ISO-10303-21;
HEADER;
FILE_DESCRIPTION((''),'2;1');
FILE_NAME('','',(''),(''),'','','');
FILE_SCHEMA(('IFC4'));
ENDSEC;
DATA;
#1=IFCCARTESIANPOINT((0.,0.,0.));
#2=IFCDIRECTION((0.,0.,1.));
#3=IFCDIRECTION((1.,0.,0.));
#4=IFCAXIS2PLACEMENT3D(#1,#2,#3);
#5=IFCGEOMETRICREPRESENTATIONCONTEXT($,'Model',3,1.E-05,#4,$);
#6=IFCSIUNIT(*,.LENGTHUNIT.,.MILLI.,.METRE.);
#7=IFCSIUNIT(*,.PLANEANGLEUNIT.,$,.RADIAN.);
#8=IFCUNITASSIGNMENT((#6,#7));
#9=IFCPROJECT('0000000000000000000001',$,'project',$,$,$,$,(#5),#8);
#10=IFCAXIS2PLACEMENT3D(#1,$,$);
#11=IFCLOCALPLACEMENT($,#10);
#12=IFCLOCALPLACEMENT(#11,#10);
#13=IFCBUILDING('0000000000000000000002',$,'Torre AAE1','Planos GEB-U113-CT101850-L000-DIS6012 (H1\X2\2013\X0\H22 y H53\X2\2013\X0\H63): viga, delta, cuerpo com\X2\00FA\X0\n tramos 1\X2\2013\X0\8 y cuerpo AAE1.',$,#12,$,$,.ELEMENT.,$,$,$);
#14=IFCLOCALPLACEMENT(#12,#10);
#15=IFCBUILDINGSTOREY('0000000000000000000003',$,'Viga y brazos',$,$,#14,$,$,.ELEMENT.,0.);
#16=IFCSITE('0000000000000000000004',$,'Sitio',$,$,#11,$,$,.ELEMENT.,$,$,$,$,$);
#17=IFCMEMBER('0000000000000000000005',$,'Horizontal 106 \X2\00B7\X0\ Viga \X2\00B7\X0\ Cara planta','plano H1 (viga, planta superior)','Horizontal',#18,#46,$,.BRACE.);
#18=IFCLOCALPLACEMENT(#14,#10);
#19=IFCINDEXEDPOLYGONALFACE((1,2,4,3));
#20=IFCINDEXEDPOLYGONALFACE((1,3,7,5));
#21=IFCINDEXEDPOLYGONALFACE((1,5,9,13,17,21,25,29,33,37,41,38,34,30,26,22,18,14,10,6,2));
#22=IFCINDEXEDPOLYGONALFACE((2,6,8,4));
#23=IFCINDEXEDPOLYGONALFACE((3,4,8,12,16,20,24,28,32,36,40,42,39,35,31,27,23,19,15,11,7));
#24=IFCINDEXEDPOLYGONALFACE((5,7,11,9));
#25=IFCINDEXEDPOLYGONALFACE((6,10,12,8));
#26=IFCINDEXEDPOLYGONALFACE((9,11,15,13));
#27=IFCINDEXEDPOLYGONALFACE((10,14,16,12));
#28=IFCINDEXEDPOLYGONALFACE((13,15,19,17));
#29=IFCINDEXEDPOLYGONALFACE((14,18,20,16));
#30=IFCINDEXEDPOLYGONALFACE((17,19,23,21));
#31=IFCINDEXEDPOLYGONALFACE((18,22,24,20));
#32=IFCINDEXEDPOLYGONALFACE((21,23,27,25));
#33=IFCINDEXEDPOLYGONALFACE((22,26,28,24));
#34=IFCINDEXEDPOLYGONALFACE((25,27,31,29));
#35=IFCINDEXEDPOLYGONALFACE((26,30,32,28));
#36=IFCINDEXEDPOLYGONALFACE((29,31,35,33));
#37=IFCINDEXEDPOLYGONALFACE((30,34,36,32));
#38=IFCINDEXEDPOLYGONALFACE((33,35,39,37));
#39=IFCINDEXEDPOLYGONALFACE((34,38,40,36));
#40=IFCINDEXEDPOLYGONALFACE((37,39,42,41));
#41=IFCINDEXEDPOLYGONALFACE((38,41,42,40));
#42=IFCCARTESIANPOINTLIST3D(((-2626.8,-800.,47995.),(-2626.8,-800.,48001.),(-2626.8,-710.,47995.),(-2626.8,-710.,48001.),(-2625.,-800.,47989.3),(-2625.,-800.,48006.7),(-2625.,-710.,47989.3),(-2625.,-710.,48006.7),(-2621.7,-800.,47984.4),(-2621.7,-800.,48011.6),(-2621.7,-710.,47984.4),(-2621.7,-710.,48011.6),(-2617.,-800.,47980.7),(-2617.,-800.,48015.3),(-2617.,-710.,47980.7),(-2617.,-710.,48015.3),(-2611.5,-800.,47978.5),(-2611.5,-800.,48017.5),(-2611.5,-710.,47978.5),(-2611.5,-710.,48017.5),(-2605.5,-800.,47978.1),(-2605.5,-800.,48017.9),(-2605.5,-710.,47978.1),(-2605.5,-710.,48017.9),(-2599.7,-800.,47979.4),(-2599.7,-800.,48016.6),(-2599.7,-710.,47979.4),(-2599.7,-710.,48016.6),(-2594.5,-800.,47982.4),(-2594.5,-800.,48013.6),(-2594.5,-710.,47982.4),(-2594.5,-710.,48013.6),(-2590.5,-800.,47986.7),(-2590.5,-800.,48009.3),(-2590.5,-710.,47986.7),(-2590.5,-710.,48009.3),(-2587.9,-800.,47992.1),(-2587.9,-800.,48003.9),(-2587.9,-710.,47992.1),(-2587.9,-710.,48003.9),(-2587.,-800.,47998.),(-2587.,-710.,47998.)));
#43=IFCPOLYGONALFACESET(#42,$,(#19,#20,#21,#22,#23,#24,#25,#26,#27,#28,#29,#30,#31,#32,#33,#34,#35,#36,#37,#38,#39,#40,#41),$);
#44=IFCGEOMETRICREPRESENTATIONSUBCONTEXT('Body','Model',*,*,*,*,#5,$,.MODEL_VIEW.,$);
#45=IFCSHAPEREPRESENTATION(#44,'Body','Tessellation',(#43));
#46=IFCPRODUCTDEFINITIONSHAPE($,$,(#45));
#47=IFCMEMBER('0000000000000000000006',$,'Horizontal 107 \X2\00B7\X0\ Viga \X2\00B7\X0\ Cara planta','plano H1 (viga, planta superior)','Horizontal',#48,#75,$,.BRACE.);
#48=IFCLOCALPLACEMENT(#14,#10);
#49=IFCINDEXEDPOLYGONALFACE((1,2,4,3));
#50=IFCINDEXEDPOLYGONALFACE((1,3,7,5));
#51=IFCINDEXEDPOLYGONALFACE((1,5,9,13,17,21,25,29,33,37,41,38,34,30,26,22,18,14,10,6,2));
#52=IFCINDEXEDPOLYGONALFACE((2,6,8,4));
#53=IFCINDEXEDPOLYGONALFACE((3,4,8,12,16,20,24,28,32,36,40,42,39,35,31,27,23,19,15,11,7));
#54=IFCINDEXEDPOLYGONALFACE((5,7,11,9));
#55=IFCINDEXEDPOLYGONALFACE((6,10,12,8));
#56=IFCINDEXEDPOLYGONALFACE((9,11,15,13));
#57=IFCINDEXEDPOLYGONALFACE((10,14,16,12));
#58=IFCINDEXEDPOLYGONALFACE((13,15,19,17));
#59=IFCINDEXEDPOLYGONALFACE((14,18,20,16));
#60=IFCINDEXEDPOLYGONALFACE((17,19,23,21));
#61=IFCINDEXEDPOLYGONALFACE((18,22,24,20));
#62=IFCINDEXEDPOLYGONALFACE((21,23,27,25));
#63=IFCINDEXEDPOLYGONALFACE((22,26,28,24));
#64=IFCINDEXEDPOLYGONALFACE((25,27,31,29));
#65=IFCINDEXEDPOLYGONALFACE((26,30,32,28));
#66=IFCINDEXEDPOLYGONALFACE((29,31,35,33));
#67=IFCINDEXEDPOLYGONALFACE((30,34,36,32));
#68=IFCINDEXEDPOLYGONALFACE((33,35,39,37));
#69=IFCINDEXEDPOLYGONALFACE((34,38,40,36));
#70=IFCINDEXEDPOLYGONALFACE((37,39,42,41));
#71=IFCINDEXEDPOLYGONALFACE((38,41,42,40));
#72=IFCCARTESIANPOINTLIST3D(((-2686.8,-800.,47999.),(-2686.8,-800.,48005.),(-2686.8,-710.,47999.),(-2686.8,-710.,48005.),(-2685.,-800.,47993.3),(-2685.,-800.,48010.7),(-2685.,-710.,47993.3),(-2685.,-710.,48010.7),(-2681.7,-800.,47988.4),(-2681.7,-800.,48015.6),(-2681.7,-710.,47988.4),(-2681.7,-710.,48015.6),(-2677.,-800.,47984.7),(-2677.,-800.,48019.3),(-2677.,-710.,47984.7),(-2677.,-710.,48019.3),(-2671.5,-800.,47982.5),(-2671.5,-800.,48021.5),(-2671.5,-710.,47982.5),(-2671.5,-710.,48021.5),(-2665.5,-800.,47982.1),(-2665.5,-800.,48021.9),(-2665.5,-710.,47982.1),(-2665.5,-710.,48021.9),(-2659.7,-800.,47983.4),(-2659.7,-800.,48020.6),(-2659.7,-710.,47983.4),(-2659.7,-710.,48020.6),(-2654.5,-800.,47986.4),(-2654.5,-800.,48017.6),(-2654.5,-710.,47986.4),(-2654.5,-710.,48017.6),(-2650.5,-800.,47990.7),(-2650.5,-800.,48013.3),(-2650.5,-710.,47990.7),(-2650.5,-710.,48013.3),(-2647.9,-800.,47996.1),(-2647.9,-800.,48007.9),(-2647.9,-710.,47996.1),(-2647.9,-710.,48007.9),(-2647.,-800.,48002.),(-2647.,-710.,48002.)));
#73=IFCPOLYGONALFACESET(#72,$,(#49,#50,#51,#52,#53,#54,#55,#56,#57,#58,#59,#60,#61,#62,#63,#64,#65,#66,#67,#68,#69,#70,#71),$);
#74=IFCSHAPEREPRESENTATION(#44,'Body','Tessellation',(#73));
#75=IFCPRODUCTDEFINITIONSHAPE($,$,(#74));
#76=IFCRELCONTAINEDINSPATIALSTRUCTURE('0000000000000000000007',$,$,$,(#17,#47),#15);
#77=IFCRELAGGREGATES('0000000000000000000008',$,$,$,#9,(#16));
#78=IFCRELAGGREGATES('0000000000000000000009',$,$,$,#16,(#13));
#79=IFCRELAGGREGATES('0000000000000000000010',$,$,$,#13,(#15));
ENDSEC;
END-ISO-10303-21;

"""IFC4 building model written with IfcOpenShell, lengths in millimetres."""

from ifc_helpers import new_model, si_unit, frame, origin, origin_with_axes, place, context, subcontext, project, spatial, circle, extrude, element, save


model = new_model("IFC4")

# Units and contexts
model_context = context("Model", 3, precision=1e-05, world=origin_with_axes())
body_context = subcontext(model_context, "Body", "Model", "MODEL_VIEW")
ifc_project = project(units=[si_unit("LENGTHUNIT", "METRE", prefix="MILLI"), si_unit("PLANEANGLEUNIT", "RADIAN")], contexts=[model_context])

# Site, building, storey
site_placement = place(None, origin())
site = spatial("IfcSite", under=ifc_project, at=site_placement, Name="Sitio", CompositionType="ELEMENT")
building_placement = place(site_placement, origin())
building = spatial("IfcBuilding", under=site, at=building_placement, Name="Torre AAE1", Description="Planos GEB-U113-CT101850-L000-DIS6012 (H1–H22 y H53–H63): viga, delta, cuerpo común tramos 1–8 y cuerpo AAE1.", CompositionType="ELEMENT")
storey_placement = place(building_placement, origin())
storey = spatial("IfcBuildingStorey", under=building, at=storey_placement, Name="Viga y brazos", CompositionType="ELEMENT", Elevation=0.0)

# Members
for number, where, z_axis, x_axis, name in (
    (1, (-2607.0, -710.0, 47998.0), (0.0, -1.0, 0.0), (1.0, 0.0, 0.0), "Horizontal 106 · Viga · Cara planta"),
    (2, (-2667.0, -710.0, 48002.0), (0.0, -1.0, 0.0), (1.0, 0.0, 0.0), "Horizontal 107 · Viga · Cara planta"),
):
    element("IfcMember", number, at=place(storey_placement, frame(where, z_axis=z_axis, x_axis=x_axis)), inside=storey, Name=name, Description="plano H1 (viga, planta superior)", ObjectType="Horizontal", PredefinedType="BRACE", context=body_context, shape_type="SweptSolid", body=[
        extrude(circle(Radius=20.0), None, (0.0, 0.0, 1.0), 90.0),
    ])

save(model, "model.ifc")
